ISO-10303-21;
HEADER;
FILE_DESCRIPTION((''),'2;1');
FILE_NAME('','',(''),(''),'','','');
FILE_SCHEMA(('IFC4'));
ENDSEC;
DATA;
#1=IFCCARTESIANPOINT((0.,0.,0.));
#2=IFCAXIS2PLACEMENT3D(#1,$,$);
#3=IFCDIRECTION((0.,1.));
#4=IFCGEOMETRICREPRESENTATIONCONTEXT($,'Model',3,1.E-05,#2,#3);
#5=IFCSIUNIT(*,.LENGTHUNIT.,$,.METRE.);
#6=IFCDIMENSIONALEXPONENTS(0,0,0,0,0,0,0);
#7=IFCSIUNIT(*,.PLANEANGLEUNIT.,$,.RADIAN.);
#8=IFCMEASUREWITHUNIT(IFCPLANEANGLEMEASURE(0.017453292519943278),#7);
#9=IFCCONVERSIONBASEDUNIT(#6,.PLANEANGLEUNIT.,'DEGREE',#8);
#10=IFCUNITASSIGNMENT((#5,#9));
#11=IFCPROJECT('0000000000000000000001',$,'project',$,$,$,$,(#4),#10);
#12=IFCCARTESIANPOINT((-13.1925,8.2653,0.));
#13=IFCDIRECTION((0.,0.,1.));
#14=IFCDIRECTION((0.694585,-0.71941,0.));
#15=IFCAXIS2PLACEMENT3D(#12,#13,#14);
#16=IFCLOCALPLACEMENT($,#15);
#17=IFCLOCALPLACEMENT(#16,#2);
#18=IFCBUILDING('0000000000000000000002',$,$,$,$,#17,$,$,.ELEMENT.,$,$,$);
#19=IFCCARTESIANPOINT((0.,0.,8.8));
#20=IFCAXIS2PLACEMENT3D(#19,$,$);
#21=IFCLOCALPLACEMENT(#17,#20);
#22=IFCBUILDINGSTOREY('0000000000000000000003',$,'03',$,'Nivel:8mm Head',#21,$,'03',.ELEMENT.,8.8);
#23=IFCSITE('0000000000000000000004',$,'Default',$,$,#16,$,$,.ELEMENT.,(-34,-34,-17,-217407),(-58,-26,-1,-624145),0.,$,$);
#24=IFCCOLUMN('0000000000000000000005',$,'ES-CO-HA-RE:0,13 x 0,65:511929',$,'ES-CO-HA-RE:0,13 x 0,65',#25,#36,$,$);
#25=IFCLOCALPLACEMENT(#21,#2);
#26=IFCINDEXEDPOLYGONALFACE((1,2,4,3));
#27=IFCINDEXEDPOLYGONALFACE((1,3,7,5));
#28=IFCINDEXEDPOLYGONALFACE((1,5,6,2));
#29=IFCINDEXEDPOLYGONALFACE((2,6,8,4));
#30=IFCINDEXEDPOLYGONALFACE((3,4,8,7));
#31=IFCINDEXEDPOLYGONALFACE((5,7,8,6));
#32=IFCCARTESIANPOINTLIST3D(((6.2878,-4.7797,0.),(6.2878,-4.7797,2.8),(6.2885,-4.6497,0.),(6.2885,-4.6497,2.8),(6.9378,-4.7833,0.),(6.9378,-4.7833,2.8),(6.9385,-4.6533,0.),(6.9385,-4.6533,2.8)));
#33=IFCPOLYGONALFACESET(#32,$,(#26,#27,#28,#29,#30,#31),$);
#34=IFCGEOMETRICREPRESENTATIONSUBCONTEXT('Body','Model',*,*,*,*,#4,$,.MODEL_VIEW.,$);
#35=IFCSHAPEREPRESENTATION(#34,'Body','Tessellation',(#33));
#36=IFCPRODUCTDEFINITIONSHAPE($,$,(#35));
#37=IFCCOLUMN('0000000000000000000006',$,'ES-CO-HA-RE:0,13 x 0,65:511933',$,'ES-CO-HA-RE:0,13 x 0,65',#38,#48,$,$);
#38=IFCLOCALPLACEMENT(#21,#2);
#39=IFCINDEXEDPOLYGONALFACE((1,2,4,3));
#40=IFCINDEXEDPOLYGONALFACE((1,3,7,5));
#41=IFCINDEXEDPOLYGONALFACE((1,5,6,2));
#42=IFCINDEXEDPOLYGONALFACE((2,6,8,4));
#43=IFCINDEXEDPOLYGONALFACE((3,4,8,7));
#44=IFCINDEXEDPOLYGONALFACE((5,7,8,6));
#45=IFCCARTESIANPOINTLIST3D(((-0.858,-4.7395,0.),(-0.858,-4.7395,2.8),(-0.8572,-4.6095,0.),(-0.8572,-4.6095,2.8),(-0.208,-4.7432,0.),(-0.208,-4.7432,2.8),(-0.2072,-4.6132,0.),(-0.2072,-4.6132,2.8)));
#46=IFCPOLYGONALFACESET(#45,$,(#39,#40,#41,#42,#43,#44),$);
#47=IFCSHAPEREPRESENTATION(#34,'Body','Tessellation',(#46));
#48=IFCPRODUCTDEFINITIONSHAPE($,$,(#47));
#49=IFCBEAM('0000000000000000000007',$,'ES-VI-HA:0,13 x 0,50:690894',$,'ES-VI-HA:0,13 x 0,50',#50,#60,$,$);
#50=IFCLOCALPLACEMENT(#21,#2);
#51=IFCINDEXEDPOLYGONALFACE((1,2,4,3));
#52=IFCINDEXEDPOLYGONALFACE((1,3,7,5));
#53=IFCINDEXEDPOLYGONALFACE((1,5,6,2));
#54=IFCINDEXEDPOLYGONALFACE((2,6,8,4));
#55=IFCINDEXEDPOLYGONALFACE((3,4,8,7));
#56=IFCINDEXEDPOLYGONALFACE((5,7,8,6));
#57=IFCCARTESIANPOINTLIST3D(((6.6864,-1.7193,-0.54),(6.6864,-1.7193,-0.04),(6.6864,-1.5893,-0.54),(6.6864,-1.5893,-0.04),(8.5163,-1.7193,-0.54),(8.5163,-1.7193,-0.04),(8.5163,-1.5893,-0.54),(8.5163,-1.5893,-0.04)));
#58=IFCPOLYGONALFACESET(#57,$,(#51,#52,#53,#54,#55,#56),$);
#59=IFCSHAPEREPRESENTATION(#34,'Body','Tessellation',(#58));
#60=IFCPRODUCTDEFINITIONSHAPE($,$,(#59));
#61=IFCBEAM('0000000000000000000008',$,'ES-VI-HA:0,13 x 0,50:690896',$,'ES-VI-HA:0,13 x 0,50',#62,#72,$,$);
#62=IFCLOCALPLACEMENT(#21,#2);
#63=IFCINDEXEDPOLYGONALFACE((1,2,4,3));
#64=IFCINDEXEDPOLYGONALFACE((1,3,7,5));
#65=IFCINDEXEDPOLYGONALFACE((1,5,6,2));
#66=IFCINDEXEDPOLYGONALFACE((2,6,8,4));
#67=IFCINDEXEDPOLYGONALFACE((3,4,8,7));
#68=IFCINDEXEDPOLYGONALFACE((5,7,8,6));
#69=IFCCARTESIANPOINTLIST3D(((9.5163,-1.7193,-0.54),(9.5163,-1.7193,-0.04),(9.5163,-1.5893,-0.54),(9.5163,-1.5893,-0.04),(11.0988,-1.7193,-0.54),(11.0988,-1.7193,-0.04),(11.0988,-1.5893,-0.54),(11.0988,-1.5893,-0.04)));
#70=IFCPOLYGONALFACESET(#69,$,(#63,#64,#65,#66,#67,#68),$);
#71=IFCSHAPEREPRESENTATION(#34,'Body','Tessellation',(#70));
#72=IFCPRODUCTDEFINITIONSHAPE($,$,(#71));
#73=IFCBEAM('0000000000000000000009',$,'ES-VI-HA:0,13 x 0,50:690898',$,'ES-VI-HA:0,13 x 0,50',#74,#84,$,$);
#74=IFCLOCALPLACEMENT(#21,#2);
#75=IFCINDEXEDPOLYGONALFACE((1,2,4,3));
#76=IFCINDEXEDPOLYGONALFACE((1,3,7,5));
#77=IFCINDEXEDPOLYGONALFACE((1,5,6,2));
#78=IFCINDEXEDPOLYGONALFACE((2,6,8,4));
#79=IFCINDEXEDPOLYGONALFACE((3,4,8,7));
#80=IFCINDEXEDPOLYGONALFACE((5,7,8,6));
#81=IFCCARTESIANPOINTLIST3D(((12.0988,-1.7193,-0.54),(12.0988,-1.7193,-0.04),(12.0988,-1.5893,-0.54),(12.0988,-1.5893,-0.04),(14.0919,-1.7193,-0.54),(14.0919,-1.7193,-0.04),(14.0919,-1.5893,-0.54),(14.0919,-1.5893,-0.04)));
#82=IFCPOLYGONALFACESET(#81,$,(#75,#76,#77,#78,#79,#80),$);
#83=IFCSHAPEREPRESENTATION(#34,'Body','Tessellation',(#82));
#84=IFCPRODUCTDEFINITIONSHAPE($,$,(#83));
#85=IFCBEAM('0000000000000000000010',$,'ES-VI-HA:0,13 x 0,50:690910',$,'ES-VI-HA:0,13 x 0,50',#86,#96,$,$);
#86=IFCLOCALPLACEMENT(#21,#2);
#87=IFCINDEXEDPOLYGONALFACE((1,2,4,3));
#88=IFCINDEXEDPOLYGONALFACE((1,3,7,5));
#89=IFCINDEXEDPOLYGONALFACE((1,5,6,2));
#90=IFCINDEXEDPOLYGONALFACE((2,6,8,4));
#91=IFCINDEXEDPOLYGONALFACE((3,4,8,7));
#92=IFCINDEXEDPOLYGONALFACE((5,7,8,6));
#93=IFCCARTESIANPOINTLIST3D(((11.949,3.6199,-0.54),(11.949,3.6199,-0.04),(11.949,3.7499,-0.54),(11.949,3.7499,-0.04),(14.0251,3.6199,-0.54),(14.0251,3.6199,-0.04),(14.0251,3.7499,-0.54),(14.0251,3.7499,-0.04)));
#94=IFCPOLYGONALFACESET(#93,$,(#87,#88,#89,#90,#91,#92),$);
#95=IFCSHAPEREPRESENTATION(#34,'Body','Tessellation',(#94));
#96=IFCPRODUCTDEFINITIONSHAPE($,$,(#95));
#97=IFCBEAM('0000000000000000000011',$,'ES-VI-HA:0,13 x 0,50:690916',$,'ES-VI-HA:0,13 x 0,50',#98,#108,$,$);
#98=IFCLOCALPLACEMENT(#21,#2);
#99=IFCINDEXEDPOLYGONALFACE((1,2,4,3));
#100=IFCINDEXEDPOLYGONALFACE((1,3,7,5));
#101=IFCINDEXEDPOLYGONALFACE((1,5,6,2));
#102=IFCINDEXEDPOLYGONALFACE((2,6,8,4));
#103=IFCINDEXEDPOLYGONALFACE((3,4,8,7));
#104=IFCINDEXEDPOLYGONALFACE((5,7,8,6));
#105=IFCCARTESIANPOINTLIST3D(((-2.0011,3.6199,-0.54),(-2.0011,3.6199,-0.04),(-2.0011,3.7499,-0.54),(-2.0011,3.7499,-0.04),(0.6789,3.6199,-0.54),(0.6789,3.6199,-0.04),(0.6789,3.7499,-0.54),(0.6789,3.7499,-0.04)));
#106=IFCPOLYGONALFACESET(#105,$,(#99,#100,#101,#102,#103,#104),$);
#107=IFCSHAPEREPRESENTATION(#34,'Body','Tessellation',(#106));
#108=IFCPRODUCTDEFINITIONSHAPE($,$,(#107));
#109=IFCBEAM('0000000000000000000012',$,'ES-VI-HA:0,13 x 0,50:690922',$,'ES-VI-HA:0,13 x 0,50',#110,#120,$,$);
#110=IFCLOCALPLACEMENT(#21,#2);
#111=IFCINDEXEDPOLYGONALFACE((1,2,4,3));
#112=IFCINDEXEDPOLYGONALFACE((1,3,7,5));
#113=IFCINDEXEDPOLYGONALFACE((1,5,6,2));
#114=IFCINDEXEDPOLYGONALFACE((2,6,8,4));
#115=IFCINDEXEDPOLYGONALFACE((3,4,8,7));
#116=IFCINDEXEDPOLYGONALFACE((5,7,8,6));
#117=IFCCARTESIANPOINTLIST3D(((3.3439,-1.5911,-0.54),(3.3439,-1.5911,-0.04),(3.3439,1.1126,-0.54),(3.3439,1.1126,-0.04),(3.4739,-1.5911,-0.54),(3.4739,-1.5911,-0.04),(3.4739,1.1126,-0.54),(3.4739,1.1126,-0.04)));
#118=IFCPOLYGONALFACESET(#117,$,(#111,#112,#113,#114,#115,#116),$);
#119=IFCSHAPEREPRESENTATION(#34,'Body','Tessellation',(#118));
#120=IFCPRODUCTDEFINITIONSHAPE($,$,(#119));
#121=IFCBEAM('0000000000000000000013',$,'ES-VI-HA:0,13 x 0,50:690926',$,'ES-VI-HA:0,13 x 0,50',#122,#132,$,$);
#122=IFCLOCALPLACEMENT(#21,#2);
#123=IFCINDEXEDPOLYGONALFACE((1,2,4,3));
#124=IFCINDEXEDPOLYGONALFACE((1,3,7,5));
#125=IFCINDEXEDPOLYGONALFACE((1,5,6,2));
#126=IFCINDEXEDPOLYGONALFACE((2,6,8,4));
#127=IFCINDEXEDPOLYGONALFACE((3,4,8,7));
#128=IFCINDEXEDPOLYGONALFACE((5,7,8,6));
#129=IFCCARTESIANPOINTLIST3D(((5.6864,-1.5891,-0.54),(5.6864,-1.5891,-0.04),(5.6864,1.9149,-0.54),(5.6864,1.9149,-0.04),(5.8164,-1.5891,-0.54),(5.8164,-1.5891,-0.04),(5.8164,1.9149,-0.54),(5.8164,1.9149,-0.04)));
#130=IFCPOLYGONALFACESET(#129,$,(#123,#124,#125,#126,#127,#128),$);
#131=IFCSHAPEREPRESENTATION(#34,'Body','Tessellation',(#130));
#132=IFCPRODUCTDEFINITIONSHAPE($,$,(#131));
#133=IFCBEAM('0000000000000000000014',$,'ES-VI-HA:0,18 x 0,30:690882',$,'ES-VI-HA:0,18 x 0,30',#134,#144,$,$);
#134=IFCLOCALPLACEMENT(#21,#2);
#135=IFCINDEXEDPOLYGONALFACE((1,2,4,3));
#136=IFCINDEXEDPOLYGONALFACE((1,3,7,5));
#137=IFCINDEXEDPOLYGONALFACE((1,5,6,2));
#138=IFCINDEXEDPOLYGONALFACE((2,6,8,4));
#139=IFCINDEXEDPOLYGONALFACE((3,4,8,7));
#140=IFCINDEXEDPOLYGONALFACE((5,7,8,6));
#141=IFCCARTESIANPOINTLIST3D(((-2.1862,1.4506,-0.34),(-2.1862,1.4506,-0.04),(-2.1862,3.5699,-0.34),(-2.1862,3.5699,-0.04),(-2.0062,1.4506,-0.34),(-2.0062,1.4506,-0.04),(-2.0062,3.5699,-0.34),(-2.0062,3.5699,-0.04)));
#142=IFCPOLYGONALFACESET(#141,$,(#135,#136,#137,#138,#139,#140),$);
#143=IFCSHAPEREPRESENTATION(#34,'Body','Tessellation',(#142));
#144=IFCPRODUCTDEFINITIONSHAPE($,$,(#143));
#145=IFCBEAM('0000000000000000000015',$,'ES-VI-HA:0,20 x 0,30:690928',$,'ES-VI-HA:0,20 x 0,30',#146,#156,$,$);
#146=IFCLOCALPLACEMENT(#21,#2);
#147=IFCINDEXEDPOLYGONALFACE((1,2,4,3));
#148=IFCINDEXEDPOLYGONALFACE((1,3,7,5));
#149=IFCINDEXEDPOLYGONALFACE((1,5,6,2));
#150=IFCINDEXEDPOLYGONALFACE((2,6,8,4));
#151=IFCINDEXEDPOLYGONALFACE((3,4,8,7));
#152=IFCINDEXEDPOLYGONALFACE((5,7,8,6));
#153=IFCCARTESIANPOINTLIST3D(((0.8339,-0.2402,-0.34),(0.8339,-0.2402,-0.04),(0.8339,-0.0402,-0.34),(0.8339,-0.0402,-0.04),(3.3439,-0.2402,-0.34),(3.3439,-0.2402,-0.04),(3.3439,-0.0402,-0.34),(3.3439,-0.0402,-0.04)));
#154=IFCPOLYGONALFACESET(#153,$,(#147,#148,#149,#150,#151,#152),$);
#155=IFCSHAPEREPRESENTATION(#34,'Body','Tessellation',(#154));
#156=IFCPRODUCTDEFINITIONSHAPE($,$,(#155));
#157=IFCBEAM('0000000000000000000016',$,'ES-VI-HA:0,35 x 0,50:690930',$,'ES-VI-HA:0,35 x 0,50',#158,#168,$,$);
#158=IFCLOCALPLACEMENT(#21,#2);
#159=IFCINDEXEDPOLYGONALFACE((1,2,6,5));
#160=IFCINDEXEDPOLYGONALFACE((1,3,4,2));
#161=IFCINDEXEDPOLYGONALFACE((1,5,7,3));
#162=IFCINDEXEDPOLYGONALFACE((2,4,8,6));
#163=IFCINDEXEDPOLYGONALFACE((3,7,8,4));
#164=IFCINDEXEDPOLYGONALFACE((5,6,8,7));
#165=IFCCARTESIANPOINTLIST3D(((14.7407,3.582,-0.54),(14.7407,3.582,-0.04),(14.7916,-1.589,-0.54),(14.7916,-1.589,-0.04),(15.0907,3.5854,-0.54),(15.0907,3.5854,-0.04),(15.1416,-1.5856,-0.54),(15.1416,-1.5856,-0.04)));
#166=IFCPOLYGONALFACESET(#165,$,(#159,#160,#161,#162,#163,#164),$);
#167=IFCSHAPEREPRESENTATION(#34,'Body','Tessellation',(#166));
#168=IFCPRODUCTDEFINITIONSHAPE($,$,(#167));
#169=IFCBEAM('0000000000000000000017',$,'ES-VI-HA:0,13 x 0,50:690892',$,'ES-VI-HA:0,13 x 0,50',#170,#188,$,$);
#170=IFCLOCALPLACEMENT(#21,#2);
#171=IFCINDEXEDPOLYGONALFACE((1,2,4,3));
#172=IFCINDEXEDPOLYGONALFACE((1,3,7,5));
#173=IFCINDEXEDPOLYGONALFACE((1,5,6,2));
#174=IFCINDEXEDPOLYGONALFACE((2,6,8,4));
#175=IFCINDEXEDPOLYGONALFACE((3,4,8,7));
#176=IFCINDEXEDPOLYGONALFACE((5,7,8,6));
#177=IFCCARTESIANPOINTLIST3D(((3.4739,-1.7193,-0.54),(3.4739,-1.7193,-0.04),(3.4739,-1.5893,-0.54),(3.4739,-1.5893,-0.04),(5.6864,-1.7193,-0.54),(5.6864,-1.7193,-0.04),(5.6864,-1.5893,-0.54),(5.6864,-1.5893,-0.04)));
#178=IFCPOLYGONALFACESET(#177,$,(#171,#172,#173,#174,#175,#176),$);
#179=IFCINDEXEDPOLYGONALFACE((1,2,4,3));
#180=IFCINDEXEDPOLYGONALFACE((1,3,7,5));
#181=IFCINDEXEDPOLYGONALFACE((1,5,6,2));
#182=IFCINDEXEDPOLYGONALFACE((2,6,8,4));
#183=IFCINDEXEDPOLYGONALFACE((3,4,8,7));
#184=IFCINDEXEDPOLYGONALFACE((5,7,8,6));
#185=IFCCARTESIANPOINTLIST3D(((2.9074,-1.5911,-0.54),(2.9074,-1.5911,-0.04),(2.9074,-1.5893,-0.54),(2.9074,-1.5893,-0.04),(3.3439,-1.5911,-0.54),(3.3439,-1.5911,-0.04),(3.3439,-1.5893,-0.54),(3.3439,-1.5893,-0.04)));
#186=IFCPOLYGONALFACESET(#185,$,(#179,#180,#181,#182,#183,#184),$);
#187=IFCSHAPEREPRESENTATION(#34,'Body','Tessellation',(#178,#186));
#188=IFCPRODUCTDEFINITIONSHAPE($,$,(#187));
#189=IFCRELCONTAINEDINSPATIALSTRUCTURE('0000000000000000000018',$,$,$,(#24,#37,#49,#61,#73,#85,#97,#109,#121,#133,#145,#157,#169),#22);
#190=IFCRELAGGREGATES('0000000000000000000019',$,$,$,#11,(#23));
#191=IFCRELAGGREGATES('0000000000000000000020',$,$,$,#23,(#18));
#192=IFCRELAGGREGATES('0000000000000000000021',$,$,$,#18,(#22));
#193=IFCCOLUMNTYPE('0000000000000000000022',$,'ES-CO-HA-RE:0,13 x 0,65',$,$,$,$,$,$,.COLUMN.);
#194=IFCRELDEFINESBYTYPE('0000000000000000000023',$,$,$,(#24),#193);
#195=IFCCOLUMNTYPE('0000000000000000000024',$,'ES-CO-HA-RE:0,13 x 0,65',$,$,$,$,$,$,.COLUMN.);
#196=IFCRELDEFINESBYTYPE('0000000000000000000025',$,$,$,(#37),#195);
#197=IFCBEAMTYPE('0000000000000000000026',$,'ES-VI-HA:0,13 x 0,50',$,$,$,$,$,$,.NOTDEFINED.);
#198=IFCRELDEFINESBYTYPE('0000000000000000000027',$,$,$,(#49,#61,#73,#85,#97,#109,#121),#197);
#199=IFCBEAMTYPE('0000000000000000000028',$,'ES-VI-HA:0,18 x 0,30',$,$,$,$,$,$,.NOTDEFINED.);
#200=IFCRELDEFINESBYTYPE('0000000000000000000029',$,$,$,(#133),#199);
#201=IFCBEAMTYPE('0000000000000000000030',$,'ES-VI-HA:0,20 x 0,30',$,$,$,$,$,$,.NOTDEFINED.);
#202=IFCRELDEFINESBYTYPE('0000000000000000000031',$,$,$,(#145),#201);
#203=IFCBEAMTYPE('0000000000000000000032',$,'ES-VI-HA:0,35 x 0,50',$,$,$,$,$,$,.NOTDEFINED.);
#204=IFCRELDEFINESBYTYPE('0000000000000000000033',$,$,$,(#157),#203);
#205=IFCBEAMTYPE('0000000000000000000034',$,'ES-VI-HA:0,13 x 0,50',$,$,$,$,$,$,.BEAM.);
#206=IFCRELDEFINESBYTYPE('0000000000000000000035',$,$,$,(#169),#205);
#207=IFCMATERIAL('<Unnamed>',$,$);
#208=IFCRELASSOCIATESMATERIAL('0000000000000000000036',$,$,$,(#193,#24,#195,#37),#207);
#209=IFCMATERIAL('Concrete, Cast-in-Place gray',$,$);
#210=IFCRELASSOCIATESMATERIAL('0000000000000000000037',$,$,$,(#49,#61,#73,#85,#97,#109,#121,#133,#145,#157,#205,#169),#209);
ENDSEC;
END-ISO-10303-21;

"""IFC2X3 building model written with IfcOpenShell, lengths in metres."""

from ifc_helpers import new_model, entity, si_unit, converted_unit, direction, frame, frame_2d, origin, origin_2d_with_axis, place, context, subcontext, project, spatial, rectangle, extrude, source, transform, mapped, material, type_object, type_shapes, element, save


model = new_model("IFC2X3")

# Units and contexts
model_context = context("Model", 3, precision=1e-05, world=origin(), true_north=direction((0.0, 1.0)))
body_context = subcontext(model_context, "Body", "Model", "MODEL_VIEW")
ifc_project = project(units=[si_unit("LENGTHUNIT", "METRE"), converted_unit("PLANEANGLEUNIT", "DEGREE", entity("IfcPlaneAngleMeasure", 0.017453292519943278), si_unit("PLANEANGLEUNIT", "RADIAN"), dimensions=[0, 0, 0, 0, 0, 0, 0])], contexts=[model_context])

# Site, building, storey
site_placement = place(None, frame((-13.1925, 8.2653, 0.0), z_axis=(0.0, 0.0, 1.0), x_axis=(0.694585, -0.71941, 0.0)))
site = spatial("IfcSite", under=ifc_project, at=site_placement, Name="Default", CompositionType="ELEMENT", RefLatitude=(-34, -34, -17, -217407), RefLongitude=(-58, -26, -1, -624145), RefElevation=0.0)
building_placement = place(site_placement, origin())
building = spatial("IfcBuilding", under=site, at=building_placement, CompositionType="ELEMENT")
storey_placement = place(building_placement, frame((0.0, 0.0, 8.8)))
storey = spatial("IfcBuildingStorey", under=building, at=storey_placement, Name="03", ObjectType="Nivel:8mm Head", LongName="03", CompositionType="ELEMENT", Elevation=8.8)

# Columns
ifc_material_1 = material(Name="<Unnamed>")
column_type_1 = type_object("IfcColumnType", Name="ES-CO-HA-RE:0,13 x 0,65", PredefinedType="COLUMN", material=ifc_material_1)
shared_shape_1 = source(origin(), body_context, "Body", "SweptSolid", [
    extrude(rectangle(XDim=0.65, YDim=0.13, at=frame_2d((0.0, 0.0), x_axis=(1.0, 0.0))), frame((6.6131, -4.7165, 8.8), z_axis=(0.0, 0.0, 1.0), x_axis=(-0.999984, 0.005619, 0.0)), (0.0, 0.0, 1.0), 2.8),
])
type_shapes(column_type_1, [shared_shape_1])
column_1_placement = place(storey_placement, frame((0.0, 0.0, -8.8)))
element("IfcColumn", 1, at=column_1_placement, inside=storey, type_object=column_type_1, material=ifc_material_1, Name="ES-CO-HA-RE:0,13 x 0,65:511929", ObjectType="ES-CO-HA-RE:0,13 x 0,65", context=body_context, shape_type="MappedRepresentation", body=[
    mapped(shared_shape_1, transform((0.0, 0.0, 0.0), scale=1.0)),
])
column_type_2 = type_object("IfcColumnType", Name="ES-CO-HA-RE:0,13 x 0,65", PredefinedType="COLUMN", material=ifc_material_1)
shared_shape_2 = source(origin(), body_context, "Body", "SweptSolid", [
    extrude(rectangle(XDim=0.65, YDim=0.13, at=frame_2d((0.0, 0.0), x_axis=(1.0, 0.0))), frame((-0.5326, -4.6764, 8.8), z_axis=(0.0, 0.0, 1.0), x_axis=(-0.999984, 0.005619, 0.0)), (0.0, 0.0, 1.0), 2.8),
])
type_shapes(column_type_2, [shared_shape_2])
column_2_placement = place(storey_placement, frame((0.0, 0.0, -8.8)))
element("IfcColumn", 2, at=column_2_placement, inside=storey, type_object=column_type_2, material=ifc_material_1, Name="ES-CO-HA-RE:0,13 x 0,65:511933", ObjectType="ES-CO-HA-RE:0,13 x 0,65", context=body_context, shape_type="MappedRepresentation", body=[
    mapped(shared_shape_2, transform((0.0, 0.0, 0.0), scale=1.0)),
])

# Beams
ifc_material_2 = material(Name="Concrete, Cast-in-Place gray")
beam_type_1 = type_object("IfcBeamType", Name="ES-VI-HA:0,13 x 0,50", PredefinedType="NOTDEFINED")
beam_1_placement = place(storey_placement, frame((5.7373, -1.6543, -0.04)))
element("IfcBeam", 3, at=beam_1_placement, inside=storey, type_object=beam_type_1, material=ifc_material_2, Name="ES-VI-HA:0,13 x 0,50:690894", ObjectType="ES-VI-HA:0,13 x 0,50", context=body_context, shape_type="SweptSolid", body=[
    extrude(rectangle(XDim=0.5, YDim=0.13, at=frame_2d((0.0, 0.0), x_axis=(1.0, 0.0))), frame((0.9491, 0.0, -0.25), z_axis=(1.0, 0.0, 0.0), x_axis=(0.0, 0.0, -1.0)), (0.0, 0.0, 1.0), 1.8299),
])
beam_2_placement = place(storey_placement, frame((8.3198, -1.6543, -0.04)))
element("IfcBeam", 4, at=beam_2_placement, inside=storey, type_object=beam_type_1, material=ifc_material_2, Name="ES-VI-HA:0,13 x 0,50:690896", ObjectType="ES-VI-HA:0,13 x 0,50", context=body_context, shape_type="SweptSolid", body=[
    extrude(rectangle(XDim=0.5, YDim=0.13, at=frame_2d((0.0, 0.0), x_axis=(1.0, 0.0))), frame((1.1965, 0.0, -0.25), z_axis=(1.0, 0.0, 0.0), x_axis=(0.0, 0.0, -1.0)), (0.0, 0.0, 1.0), 1.5825),
])
beam_3_placement = place(storey_placement, frame((11.3129, -1.6543, -0.04)))
element("IfcBeam", 5, at=beam_3_placement, inside=storey, type_object=beam_type_1, material=ifc_material_2, Name="ES-VI-HA:0,13 x 0,50:690898", ObjectType="ES-VI-HA:0,13 x 0,50", context=body_context, shape_type="SweptSolid", body=[
    extrude(rectangle(XDim=0.5, YDim=0.13, at=frame_2d((0.0, 0.0), x_axis=(1.0, 0.0))), frame((0.7858, 0.0, -0.25), z_axis=(1.0, 0.0, 0.0), x_axis=(0.0, 0.0, -1.0)), (0.0, 0.0, 1.0), 1.9932),
])
beam_4_placement = place(storey_placement, frame((11.624, 3.6849, -0.04)))
element("IfcBeam", 6, at=beam_4_placement, inside=storey, type_object=beam_type_1, material=ifc_material_2, Name="ES-VI-HA:0,13 x 0,50:690910", ObjectType="ES-VI-HA:0,13 x 0,50", context=body_context, shape_type="SweptSolid", body=[
    extrude(rectangle(XDim=0.5, YDim=0.13, at=frame_2d((0.0, 0.0), x_axis=(1.0, 0.0))), frame((0.325, 0.0, -0.25), z_axis=(1.0, 0.0, 0.0), x_axis=(0.0, 0.0, -1.0)), (0.0, 0.0, 1.0), 2.0761),
])
beam_5_placement = place(storey_placement, frame((-2.0011, 3.6849, -0.04)))
element("IfcBeam", 7, at=beam_5_placement, inside=storey, type_object=beam_type_1, material=ifc_material_2, Name="ES-VI-HA:0,13 x 0,50:690916", ObjectType="ES-VI-HA:0,13 x 0,50", context=body_context, shape_type="SweptSolid", body=[
    extrude(rectangle(XDim=0.5, YDim=0.13, at=frame_2d((0.0, 0.0), x_axis=(1.0, 0.0))), frame((0.0, 0.0, -0.25), z_axis=(1.0, 0.0, 0.0), x_axis=(0.0, 0.0, -1.0)), (0.0, 0.0, 1.0), 2.68),
])
beam_6_placement = place(storey_placement, frame((3.4089, -1.5916, -0.04), z_axis=(0.0, 0.0, 1.0), x_axis=(0.0, 1.0, 0.0)))
element("IfcBeam", 8, at=beam_6_placement, inside=storey, type_object=beam_type_1, material=ifc_material_2, Name="ES-VI-HA:0,13 x 0,50:690922", ObjectType="ES-VI-HA:0,13 x 0,50", context=body_context, shape_type="SweptSolid", body=[
    extrude(rectangle(XDim=0.5, YDim=0.13, at=origin_2d_with_axis()), frame((0.0005, 0.0, -0.25), z_axis=(1.0, 0.0, 0.0), x_axis=(0.0, 0.0, -1.0)), (0.0, 0.0, 1.0), 2.7037),
])
beam_7_placement = place(storey_placement, frame((5.7514, -1.5891, -0.04), z_axis=(0.0, 0.0, 1.0), x_axis=(0.0, 1.0, 0.0)))
element("IfcBeam", 9, at=beam_7_placement, inside=storey, type_object=beam_type_1, material=ifc_material_2, Name="ES-VI-HA:0,13 x 0,50:690926", ObjectType="ES-VI-HA:0,13 x 0,50", context=body_context, shape_type="SweptSolid", body=[
    extrude(rectangle(XDim=0.5, YDim=0.13, at=frame_2d((0.0, 0.0), x_axis=(1.0, 0.0))), frame((0.0, 0.0, -0.25), z_axis=(1.0, 0.0, 0.0), x_axis=(0.0, 0.0, -1.0)), (0.0, 0.0, 1.0), 3.5039),
])
beam_type_2 = type_object("IfcBeamType", Name="ES-VI-HA:0,18 x 0,30", PredefinedType="NOTDEFINED")
beam_8_placement = place(storey_placement, frame((-2.0962, 3.5699, -0.04), z_axis=(0.0, 0.0, 1.0), x_axis=(0.0, -1.0, 0.0)))
element("IfcBeam", 10, at=beam_8_placement, inside=storey, type_object=beam_type_2, material=ifc_material_2, Name="ES-VI-HA:0,18 x 0,30:690882", ObjectType="ES-VI-HA:0,18 x 0,30", context=body_context, shape_type="SweptSolid", body=[
    extrude(rectangle(XDim=0.3, YDim=0.18, at=origin_2d_with_axis()), frame((0.0, 0.0, -0.15), z_axis=(1.0, 0.0, 0.0), x_axis=(0.0, 0.0, -1.0)), (0.0, 0.0, 1.0), 2.1193),
])
beam_type_3 = type_object("IfcBeamType", Name="ES-VI-HA:0,20 x 0,30", PredefinedType="NOTDEFINED")
beam_9_placement = place(storey_placement, frame((0.7589, -0.1402, -0.04)))
element("IfcBeam", 11, at=beam_9_placement, inside=storey, type_object=beam_type_3, material=ifc_material_2, Name="ES-VI-HA:0,20 x 0,30:690928", ObjectType="ES-VI-HA:0,20 x 0,30", context=body_context, shape_type="SweptSolid", body=[
    extrude(rectangle(XDim=0.3, YDim=0.2, at=frame_2d((0.0, 0.0), x_axis=(1.0, 0.0))), frame((0.075, 0.0, -0.15), z_axis=(1.0, 0.0, 0.0), x_axis=(0.0, 0.0, -1.0)), (0.0, 0.0, 1.0), 2.51),
])
beam_type_4 = type_object("IfcBeamType", Name="ES-VI-HA:0,35 x 0,50", PredefinedType="NOTDEFINED")
beam_10_placement = place(storey_placement, frame((14.9158, 3.5724, -0.04), z_axis=(0.0, 0.0, 1.0), x_axis=(0.009844, -0.999952, 0.0)))
element("IfcBeam", 12, at=beam_10_placement, inside=storey, type_object=beam_type_4, material=ifc_material_2, Name="ES-VI-HA:0,35 x 0,50:690930", ObjectType="ES-VI-HA:0,35 x 0,50", context=body_context, shape_type="SweptSolid", body=[
    extrude(rectangle(XDim=0.5, YDim=0.35, at=frame_2d((0.0, 0.0), x_axis=(1.0, 0.0))), frame((-0.0113, 0.0, -0.25), z_axis=(1.0, 0.0, 0.0), x_axis=(0.0, 0.0, -1.0)), (0.0, 0.0, 1.0), 5.1713),
])
beam_type_5 = type_object("IfcBeamType", Name="ES-VI-HA:0,13 x 0,50", PredefinedType="BEAM", material=ifc_material_2)
shared_shape_3 = source(origin(), body_context, "Body", "SweptSolid", [
    extrude(rectangle(XDim=0.5, YDim=0.13, at=frame_2d((0.0, 0.0), x_axis=(1.0, 0.0))), frame((3.4739, -1.6543, 8.51), z_axis=(1.0, 0.0, 0.0), x_axis=(0.0, 0.0, -1.0)), (0.0, 0.0, 1.0), 2.2125),
    extrude(rectangle(XDim=0.5, YDim=0.0018, at=frame_2d((0.0, 0.0), x_axis=(1.0, 0.0))), frame((2.9074, -1.5902, 8.51), z_axis=(1.0, 0.0, 0.0), x_axis=(0.0, 0.0, -1.0)), (0.0, 0.0, 1.0), 0.4365),
])
type_shapes(beam_type_5, [shared_shape_3])
beam_11_placement = place(storey_placement, frame((0.0, 0.0, -8.8)))
element("IfcBeam", 13, at=beam_11_placement, inside=storey, type_object=beam_type_5, material=ifc_material_2, Name="ES-VI-HA:0,13 x 0,50:690892", ObjectType="ES-VI-HA:0,13 x 0,50", context=body_context, shape_type="MappedRepresentation", body=[
    mapped(shared_shape_3, transform((0.0, 0.0, 0.0), scale=1.0)),
])

save(model, "model.ifc")
